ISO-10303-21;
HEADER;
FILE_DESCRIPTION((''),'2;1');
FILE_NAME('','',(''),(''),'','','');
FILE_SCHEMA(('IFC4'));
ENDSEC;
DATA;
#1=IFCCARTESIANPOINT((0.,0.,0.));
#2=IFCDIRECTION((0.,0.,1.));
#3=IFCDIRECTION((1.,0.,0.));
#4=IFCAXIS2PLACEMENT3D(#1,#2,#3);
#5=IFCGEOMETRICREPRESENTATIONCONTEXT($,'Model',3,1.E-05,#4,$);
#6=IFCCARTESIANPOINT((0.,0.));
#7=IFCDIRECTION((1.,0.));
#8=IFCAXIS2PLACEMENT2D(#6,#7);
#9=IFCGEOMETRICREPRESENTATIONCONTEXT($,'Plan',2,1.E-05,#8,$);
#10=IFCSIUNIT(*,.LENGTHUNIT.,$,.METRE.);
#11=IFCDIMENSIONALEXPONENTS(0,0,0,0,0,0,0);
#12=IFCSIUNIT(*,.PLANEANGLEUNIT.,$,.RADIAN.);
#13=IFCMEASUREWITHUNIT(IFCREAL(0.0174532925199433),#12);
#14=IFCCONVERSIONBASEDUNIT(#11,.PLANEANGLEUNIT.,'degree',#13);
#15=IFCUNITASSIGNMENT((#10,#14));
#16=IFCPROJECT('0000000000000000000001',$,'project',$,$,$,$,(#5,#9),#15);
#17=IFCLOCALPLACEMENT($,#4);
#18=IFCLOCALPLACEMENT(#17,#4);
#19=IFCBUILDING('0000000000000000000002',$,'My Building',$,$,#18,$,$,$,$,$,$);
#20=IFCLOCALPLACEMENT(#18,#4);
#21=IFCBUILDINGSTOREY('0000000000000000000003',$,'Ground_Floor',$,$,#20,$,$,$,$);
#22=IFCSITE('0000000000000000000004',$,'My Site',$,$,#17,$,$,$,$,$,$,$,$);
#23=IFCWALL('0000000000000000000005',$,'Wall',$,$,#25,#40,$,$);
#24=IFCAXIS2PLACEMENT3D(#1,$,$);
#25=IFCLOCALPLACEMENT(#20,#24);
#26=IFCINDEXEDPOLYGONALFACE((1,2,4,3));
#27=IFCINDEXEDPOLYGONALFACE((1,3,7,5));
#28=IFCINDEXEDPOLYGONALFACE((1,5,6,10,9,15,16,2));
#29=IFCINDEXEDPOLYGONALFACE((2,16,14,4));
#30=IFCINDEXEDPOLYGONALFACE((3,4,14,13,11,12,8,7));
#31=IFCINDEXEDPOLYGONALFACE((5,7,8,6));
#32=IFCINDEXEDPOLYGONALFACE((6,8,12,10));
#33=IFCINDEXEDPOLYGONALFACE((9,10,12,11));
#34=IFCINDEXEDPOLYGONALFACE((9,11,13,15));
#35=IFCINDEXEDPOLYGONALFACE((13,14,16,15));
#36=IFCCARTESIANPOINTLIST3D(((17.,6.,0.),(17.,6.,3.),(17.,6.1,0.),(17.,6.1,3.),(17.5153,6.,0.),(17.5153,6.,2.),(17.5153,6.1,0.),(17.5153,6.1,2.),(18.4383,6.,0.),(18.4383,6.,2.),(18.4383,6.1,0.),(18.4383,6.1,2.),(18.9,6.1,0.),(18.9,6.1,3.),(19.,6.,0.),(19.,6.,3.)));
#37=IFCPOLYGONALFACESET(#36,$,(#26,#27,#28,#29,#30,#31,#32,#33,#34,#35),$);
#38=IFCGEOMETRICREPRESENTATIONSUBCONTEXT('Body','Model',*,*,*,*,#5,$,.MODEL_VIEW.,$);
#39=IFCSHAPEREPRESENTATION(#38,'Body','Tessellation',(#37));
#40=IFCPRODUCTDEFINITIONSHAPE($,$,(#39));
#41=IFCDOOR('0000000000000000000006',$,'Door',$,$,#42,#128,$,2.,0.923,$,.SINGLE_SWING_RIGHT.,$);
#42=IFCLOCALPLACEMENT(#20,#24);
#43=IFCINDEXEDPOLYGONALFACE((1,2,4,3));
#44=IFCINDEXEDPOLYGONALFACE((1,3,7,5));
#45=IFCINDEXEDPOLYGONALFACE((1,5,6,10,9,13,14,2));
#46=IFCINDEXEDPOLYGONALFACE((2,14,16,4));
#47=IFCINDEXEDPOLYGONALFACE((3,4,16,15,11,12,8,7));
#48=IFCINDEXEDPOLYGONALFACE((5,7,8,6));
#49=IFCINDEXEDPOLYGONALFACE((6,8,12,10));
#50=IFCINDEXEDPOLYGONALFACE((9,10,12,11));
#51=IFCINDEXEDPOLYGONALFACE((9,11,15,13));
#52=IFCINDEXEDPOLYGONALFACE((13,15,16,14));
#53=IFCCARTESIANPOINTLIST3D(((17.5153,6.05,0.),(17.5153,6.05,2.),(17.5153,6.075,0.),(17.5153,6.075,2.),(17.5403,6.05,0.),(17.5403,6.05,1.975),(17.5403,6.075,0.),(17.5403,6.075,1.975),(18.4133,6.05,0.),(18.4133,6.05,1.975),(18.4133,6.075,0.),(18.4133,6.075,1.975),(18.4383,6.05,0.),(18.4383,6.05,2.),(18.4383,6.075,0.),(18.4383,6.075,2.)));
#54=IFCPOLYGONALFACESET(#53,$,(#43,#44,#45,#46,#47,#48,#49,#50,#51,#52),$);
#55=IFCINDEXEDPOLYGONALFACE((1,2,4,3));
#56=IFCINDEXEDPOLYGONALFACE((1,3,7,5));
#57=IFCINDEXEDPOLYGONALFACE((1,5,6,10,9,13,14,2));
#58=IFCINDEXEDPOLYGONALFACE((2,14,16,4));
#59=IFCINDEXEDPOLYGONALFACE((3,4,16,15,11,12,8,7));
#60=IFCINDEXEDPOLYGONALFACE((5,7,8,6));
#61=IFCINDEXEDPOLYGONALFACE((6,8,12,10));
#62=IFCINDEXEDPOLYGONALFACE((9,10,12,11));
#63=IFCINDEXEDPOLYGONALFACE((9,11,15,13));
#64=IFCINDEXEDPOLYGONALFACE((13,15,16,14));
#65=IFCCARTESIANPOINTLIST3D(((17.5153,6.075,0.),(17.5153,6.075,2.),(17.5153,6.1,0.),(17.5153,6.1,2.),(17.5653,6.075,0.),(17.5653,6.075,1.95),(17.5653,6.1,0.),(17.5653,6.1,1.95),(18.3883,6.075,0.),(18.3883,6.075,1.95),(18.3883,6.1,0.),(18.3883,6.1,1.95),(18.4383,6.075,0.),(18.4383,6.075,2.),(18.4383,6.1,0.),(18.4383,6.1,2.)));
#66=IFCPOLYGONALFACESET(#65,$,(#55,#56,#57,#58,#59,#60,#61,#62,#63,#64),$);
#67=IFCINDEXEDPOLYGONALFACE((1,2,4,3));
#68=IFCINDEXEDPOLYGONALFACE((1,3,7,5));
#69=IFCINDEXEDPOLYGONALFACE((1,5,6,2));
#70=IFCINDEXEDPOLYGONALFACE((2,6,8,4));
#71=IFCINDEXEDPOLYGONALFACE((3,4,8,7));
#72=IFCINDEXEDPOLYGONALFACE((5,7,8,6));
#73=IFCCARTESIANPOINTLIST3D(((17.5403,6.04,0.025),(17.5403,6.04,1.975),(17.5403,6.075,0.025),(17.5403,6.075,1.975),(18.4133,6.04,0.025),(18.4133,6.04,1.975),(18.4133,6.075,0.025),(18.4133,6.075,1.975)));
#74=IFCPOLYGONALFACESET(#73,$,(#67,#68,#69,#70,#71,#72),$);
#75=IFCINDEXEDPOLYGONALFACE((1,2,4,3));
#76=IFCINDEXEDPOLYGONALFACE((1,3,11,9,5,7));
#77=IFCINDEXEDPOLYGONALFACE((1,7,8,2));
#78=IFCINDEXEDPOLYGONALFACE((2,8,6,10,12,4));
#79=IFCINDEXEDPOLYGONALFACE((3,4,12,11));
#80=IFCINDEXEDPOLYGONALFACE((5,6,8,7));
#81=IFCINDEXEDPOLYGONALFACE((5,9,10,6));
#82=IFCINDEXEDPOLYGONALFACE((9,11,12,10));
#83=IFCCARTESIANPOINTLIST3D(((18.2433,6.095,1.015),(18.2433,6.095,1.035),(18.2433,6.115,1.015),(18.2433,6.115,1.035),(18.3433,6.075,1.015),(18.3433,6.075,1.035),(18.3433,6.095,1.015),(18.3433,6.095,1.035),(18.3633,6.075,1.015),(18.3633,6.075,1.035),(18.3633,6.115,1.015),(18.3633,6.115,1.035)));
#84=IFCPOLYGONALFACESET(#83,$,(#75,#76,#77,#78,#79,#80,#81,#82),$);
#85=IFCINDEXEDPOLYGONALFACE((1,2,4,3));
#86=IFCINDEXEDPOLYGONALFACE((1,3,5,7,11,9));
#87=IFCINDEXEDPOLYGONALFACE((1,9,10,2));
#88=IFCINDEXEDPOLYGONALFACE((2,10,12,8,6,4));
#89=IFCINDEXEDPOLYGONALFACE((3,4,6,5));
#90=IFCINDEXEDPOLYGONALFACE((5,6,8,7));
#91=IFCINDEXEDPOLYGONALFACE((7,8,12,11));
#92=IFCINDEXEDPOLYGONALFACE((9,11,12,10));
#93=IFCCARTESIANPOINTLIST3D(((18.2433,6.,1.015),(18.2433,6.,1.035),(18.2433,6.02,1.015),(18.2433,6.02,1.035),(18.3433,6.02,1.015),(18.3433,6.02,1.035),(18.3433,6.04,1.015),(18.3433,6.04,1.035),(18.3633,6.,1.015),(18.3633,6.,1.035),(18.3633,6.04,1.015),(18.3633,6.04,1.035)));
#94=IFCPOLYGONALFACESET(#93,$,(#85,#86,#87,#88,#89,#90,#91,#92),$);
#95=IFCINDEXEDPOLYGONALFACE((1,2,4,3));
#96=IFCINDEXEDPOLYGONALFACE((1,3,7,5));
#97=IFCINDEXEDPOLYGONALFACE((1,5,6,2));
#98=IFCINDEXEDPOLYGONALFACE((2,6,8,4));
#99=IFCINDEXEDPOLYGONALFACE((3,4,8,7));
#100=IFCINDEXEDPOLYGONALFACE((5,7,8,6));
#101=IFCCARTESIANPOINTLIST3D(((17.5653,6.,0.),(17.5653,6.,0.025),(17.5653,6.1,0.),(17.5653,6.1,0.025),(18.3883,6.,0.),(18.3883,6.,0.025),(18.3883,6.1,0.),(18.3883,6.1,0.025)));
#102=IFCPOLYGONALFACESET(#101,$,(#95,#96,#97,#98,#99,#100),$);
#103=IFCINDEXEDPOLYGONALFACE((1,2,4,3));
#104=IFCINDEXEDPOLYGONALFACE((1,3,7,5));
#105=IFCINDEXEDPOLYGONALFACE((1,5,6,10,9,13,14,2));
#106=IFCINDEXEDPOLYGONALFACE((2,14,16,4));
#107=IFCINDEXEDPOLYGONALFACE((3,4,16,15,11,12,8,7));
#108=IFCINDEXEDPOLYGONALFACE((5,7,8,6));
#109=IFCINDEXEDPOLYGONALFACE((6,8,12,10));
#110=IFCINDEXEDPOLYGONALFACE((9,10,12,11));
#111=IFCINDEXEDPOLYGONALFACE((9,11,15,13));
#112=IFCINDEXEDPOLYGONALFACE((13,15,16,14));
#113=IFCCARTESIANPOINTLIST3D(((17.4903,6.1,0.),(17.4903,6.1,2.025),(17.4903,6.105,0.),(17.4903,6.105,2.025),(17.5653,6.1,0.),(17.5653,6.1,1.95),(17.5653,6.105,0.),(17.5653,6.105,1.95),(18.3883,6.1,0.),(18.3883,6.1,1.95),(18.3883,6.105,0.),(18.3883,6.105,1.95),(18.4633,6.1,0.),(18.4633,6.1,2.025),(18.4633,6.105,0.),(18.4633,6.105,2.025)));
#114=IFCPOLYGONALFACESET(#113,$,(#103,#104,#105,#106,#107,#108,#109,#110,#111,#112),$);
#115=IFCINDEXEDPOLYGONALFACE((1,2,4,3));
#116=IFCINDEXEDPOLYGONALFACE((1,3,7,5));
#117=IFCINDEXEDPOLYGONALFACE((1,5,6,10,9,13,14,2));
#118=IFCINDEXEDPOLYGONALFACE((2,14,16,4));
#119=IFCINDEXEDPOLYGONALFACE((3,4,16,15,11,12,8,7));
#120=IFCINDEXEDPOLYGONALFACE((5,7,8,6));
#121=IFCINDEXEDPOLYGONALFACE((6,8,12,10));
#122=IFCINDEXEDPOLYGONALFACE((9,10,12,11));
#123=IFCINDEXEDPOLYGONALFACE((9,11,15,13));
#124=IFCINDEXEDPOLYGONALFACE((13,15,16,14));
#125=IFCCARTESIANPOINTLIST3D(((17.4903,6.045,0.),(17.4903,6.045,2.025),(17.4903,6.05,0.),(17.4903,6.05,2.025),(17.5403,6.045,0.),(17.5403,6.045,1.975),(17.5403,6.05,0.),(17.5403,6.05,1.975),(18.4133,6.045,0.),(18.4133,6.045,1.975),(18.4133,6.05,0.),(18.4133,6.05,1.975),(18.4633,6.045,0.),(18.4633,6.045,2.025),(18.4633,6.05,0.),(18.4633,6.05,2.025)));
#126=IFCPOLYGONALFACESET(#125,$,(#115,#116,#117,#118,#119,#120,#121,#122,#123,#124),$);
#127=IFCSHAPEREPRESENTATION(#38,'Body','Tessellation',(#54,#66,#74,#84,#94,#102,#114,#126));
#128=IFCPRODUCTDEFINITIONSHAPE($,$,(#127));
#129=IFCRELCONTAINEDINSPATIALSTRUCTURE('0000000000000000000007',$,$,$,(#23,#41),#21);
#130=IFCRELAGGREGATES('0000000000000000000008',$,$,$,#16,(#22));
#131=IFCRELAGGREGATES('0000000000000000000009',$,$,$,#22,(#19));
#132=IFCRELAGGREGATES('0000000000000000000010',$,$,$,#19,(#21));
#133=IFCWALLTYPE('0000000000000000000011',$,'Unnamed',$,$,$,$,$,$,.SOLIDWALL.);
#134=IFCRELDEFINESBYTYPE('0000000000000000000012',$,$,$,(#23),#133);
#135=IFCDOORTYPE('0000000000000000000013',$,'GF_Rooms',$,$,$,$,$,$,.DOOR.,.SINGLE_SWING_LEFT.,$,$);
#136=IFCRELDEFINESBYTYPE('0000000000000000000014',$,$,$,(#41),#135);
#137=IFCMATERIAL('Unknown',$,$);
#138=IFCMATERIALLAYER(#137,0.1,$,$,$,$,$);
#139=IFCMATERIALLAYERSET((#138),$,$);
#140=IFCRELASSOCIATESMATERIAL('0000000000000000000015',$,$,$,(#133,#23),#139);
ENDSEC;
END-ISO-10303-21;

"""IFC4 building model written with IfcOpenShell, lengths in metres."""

from ifc_helpers import new_model, entity, si_unit, converted_unit, frame, origin_with_axes, origin_2d_with_axis, place, context, subcontext, project, spatial, line, indexed_curve, outline, extrude, shape, source, transform, mapped, material, layer, layer_set, layer_usage, type_object, type_shapes, element, fill, save


model = new_model("IFC4")

# Units and contexts
model_context = context("Model", 3, precision=1e-05, world=origin_with_axes())
plan_context = context("Plan", 2, precision=1e-05, world=origin_2d_with_axis())
body_context_1 = subcontext(model_context, "Body", "Model", "MODEL_VIEW")
body_context_2 = subcontext(plan_context, "Body", "Plan", "PLAN_VIEW")
ifc_project = project(units=[si_unit("LENGTHUNIT", "METRE"), converted_unit("PLANEANGLEUNIT", "degree", entity("IfcReal", 0.0174532925199433), si_unit("PLANEANGLEUNIT", "RADIAN"), dimensions=[0, 0, 0, 0, 0, 0, 0])], contexts=[model_context, plan_context])

# Site, building, storey
site_placement = place(None, origin_with_axes())
site = spatial("IfcSite", under=ifc_project, at=site_placement, Name="My Site")
building_placement = place(site_placement, origin_with_axes())
building = spatial("IfcBuilding", under=site, at=building_placement, Name="My Building")
storey_placement = place(building_placement, origin_with_axes())
storey = spatial("IfcBuildingStorey", under=building, at=storey_placement, Name="Ground_Floor")

# Shared definitions
ifc_material = material(Name="Unknown")
ifc_layer = layer(ifc_material, 0.1)
ifc_layer_set = layer_set([ifc_layer])
wall_type = type_object("IfcWallType", Name="Unnamed", PredefinedType="SOLIDWALL", material=ifc_layer_set)

# Wall, opening, door
shared_shape_1 = source(origin_with_axes(), body_context_1, "Body", "SweptSolid", [
    extrude(outline(indexed_curve([(0.0, 0.0), (0.923, 0.0), (0.923, 2.0), (0.0, 2.0)], segments=[line(1, 2, 3, 4, 1)])), frame((0.0, -0.6, 0.0), z_axis=(0.0, -1.0, 0.0), x_axis=(1.0, 0.0, 0.0)), (0.0, 0.0, -1.0), 1.2),
])
door_type_1 = type_object("IfcDoorType", Name="GF_Rooms", OperationType="SINGLE_SWING_LEFT", PredefinedType="DOOR")
shared_shape_2 = source(origin_with_axes(), body_context_1, "Body", "SweptSolid", [
    extrude(outline(indexed_curve([(0.0, 0.0), (0.0, 2.0), (0.923, 2.0), (0.923, 0.0), (0.898, 0.0), (0.898, 1.975), (0.025, 1.975), (0.025, 0.0)], segments=[line(1, 2, 3, 4, 5, 6, 7, 8, 1)])), frame((0.0, 0.025, 0.0), z_axis=(0.0, -1.0, 0.0), x_axis=(1.0, 0.0, 0.0)), (0.0, 0.0, -1.0), 0.025),
    extrude(outline(indexed_curve([(0.0, 0.0), (0.0, 2.0), (0.923, 2.0), (0.923, 0.0), (0.873, 0.0), (0.873, 1.95), (0.05, 1.95), (0.05, 0.0)], segments=[line(1, 2, 3, 4, 5, 6, 7, 8, 1)])), frame((0.0, 0.0, 0.0), z_axis=(0.0, -1.0, 0.0), x_axis=(1.0, 0.0, 0.0)), (0.0, 0.0, -1.0), 0.025),
    extrude(outline(indexed_curve([(0.0, 0.0), (0.873, 0.0), (0.873, 0.035), (0.0, 0.035)], segments=[line(1, 2, 3, 4, 1)])), frame((0.025, 0.025, 0.025), z_axis=(0.0, 0.0, 1.0), x_axis=(1.0, 0.0, 0.0)), (0.0, 0.0, 1.0), 1.95),
    extrude(outline(indexed_curve([(0.0, 0.0), (0.0, -0.04), (0.12, -0.04), (0.12, -0.02), (0.02, -0.02), (0.02, 0.0)], segments=[line(1, 2, 3, 4, 5, 6, 1)])), frame((0.075, 0.025, 1.015), z_axis=(0.0, 0.0, 1.0), x_axis=(1.0, 0.0, 0.0)), (0.0, 0.0, 1.0), 0.02),
    extrude(outline(indexed_curve([(0.0, 0.0), (0.0, 0.04), (0.12, 0.04), (0.12, 0.02), (0.02, 0.02), (0.02, 0.0)], segments=[line(1, 2, 3, 4, 5, 6, 1)])), frame((0.075, 0.06, 1.015), z_axis=(0.0, 0.0, 1.0), x_axis=(1.0, 0.0, 0.0)), (0.0, 0.0, 1.0), 0.02),
    extrude(outline(indexed_curve([(0.0, 0.0), (0.823, 0.0), (0.823, 0.1), (0.0, 0.1)], segments=[line(1, 2, 3, 4, 1)])), frame((0.05, 0.0, 0.0), z_axis=(0.0, 0.0, 1.0), x_axis=(1.0, 0.0, 0.0)), (0.0, 0.0, 1.0), 0.025),
    extrude(outline(indexed_curve([(0.0, 0.0), (0.0, 2.025), (0.973, 2.025), (0.973, 0.0), (0.898, 0.0), (0.898, 1.95), (0.075, 1.95), (0.075, 0.0)], segments=[line(1, 2, 3, 4, 5, 6, 7, 8, 1)])), frame((-0.025, -0.005, 0.0), z_axis=(0.0, -1.0, 0.0), x_axis=(1.0, 0.0, 0.0)), (0.0, 0.0, -1.0), 0.005),
    extrude(outline(indexed_curve([(0.0, 0.0), (0.0, 2.025), (0.973, 2.025), (0.973, 0.0), (0.923, 0.0), (0.923, 1.975), (0.05, 1.975), (0.05, 0.0)], segments=[line(1, 2, 3, 4, 5, 6, 7, 8, 1)])), frame((-0.025, 0.05, 0.0), z_axis=(0.0, -1.0, 0.0), x_axis=(1.0, 0.0, 0.0)), (0.0, 0.0, -1.0), 0.005),
])
shared_shape_3 = source(origin_with_axes(), body_context_2, "Body", "Curve2D", [
    entity("IfcIndexedPolyCurve", entity("IfcCartesianPointList2D", [[0.0, 0.0], [0.0, 0.05], [0.025, 0.05], [0.025, 0.025], [0.05, 0.025], [0.05, 0.0]]), [entity("IfcLineIndex", [1, 2, 3, 4, 5, 6, 1])]),
    entity("IfcIndexedPolyCurve", entity("IfcCartesianPointList2D", [[0.923, 0.0], [0.923, 0.05], [0.898, 0.05], [0.898, 0.025], [0.873, 0.025], [0.873, 0.0]]), [entity("IfcLineIndex", [1, 2, 3, 4, 5, 6, 1])]),
    entity("IfcTrimmedCurve", entity("IfcEllipse", entity("IfcAxis2Placement2D", entity("IfcCartesianPoint", [0.863, 0.05]), entity("IfcDirection", [1.0, 0.0])), 0.838, 0.873), [entity("IfcCartesianPoint", [0.863, 0.923])], [entity("IfcCartesianPoint", [0.025, 0.05])], True, "CARTESIAN"),
    entity("IfcIndexedPolyCurve", entity("IfcCartesianPointList2D", [[0.898, 0.05], [0.863, 0.05], [0.863, 0.923], [0.898, 0.923]]), [entity("IfcLineIndex", [1, 2, 3, 4, 1])]),
])
type_shapes(door_type_1, [shared_shape_2, shared_shape_3])
ifc_layer_usage_1 = layer_usage(ifc_layer_set, "AXIS2", "POSITIVE", 0.0)
wall_1_placement = place(storey_placement, frame((17.0, 6.0, 0.0), z_axis=(0.0, 0.0, 1.0), x_axis=(1.0, 0.0, 0.0)))
wall_1 = element("IfcWall", 1, at=wall_1_placement, inside=storey, type_object=wall_type, material=ifc_layer_usage_1, Name="Wall", context=body_context_1, shape_type="SweptSolid", body=[
    extrude(outline(indexed_curve([(0.0, 0.0), (0.0, 0.1), (1.9, 0.1), (2.0, 0.0)], segments=[line(1, 2, 3, 4, 1)])), origin_with_axes(), (0.0, 0.0, 1.0), 3.0),
])
opening_1_placement = place(wall_1_placement, frame((1.4383, 0.1, 0.0), z_axis=(0.0, 0.0, 1.0), x_axis=(-1.0, 0.0, 0.0)))
opening_1 = element("IfcOpeningElement", 2, at=opening_1_placement, cuts=wall_1, PredefinedType="OPENING", context=body_context_1, shape_type="MappedRepresentation", body=[
    mapped(shared_shape_1, transform((0.0, 0.0, 0.0), x_axis=(1.0, 0.0, 0.0), y_axis=(0.0, 1.0, 0.0), z_axis=(0.0, 0.0, 1.0), scale=1.0)),
])
door_1_placement = place(opening_1_placement, frame((0.0, 0.0, 0.0), z_axis=(0.0, 0.0, 1.0), x_axis=(1.0, 0.0, 0.0)))
door_1 = element("IfcDoor", 3, at=door_1_placement, inside=storey, type_object=door_type_1, Name="Door", OperationType="SINGLE_SWING_RIGHT", OverallHeight=2.0, OverallWidth=0.923, shapes=[
    shape(body_context_1, "Body", "MappedRepresentation", [mapped(shared_shape_2, transform((0.0, 0.0, 0.0), x_axis=(1.0, 0.0, 0.0), y_axis=(0.0, 1.0, 0.0), z_axis=(0.0, 0.0, 1.0), scale=1.0))]),
    shape(body_context_2, "Body", "MappedRepresentation", [mapped(shared_shape_3, transform((0.0, 0.0, 0.0), x_axis=(1.0, 0.0, 0.0), y_axis=(0.0, 1.0, 0.0), z_axis=(0.0, 0.0, 1.0), scale=1.0))]),
])
fill(opening_1, door_1)

save(model, "model.ifc")
